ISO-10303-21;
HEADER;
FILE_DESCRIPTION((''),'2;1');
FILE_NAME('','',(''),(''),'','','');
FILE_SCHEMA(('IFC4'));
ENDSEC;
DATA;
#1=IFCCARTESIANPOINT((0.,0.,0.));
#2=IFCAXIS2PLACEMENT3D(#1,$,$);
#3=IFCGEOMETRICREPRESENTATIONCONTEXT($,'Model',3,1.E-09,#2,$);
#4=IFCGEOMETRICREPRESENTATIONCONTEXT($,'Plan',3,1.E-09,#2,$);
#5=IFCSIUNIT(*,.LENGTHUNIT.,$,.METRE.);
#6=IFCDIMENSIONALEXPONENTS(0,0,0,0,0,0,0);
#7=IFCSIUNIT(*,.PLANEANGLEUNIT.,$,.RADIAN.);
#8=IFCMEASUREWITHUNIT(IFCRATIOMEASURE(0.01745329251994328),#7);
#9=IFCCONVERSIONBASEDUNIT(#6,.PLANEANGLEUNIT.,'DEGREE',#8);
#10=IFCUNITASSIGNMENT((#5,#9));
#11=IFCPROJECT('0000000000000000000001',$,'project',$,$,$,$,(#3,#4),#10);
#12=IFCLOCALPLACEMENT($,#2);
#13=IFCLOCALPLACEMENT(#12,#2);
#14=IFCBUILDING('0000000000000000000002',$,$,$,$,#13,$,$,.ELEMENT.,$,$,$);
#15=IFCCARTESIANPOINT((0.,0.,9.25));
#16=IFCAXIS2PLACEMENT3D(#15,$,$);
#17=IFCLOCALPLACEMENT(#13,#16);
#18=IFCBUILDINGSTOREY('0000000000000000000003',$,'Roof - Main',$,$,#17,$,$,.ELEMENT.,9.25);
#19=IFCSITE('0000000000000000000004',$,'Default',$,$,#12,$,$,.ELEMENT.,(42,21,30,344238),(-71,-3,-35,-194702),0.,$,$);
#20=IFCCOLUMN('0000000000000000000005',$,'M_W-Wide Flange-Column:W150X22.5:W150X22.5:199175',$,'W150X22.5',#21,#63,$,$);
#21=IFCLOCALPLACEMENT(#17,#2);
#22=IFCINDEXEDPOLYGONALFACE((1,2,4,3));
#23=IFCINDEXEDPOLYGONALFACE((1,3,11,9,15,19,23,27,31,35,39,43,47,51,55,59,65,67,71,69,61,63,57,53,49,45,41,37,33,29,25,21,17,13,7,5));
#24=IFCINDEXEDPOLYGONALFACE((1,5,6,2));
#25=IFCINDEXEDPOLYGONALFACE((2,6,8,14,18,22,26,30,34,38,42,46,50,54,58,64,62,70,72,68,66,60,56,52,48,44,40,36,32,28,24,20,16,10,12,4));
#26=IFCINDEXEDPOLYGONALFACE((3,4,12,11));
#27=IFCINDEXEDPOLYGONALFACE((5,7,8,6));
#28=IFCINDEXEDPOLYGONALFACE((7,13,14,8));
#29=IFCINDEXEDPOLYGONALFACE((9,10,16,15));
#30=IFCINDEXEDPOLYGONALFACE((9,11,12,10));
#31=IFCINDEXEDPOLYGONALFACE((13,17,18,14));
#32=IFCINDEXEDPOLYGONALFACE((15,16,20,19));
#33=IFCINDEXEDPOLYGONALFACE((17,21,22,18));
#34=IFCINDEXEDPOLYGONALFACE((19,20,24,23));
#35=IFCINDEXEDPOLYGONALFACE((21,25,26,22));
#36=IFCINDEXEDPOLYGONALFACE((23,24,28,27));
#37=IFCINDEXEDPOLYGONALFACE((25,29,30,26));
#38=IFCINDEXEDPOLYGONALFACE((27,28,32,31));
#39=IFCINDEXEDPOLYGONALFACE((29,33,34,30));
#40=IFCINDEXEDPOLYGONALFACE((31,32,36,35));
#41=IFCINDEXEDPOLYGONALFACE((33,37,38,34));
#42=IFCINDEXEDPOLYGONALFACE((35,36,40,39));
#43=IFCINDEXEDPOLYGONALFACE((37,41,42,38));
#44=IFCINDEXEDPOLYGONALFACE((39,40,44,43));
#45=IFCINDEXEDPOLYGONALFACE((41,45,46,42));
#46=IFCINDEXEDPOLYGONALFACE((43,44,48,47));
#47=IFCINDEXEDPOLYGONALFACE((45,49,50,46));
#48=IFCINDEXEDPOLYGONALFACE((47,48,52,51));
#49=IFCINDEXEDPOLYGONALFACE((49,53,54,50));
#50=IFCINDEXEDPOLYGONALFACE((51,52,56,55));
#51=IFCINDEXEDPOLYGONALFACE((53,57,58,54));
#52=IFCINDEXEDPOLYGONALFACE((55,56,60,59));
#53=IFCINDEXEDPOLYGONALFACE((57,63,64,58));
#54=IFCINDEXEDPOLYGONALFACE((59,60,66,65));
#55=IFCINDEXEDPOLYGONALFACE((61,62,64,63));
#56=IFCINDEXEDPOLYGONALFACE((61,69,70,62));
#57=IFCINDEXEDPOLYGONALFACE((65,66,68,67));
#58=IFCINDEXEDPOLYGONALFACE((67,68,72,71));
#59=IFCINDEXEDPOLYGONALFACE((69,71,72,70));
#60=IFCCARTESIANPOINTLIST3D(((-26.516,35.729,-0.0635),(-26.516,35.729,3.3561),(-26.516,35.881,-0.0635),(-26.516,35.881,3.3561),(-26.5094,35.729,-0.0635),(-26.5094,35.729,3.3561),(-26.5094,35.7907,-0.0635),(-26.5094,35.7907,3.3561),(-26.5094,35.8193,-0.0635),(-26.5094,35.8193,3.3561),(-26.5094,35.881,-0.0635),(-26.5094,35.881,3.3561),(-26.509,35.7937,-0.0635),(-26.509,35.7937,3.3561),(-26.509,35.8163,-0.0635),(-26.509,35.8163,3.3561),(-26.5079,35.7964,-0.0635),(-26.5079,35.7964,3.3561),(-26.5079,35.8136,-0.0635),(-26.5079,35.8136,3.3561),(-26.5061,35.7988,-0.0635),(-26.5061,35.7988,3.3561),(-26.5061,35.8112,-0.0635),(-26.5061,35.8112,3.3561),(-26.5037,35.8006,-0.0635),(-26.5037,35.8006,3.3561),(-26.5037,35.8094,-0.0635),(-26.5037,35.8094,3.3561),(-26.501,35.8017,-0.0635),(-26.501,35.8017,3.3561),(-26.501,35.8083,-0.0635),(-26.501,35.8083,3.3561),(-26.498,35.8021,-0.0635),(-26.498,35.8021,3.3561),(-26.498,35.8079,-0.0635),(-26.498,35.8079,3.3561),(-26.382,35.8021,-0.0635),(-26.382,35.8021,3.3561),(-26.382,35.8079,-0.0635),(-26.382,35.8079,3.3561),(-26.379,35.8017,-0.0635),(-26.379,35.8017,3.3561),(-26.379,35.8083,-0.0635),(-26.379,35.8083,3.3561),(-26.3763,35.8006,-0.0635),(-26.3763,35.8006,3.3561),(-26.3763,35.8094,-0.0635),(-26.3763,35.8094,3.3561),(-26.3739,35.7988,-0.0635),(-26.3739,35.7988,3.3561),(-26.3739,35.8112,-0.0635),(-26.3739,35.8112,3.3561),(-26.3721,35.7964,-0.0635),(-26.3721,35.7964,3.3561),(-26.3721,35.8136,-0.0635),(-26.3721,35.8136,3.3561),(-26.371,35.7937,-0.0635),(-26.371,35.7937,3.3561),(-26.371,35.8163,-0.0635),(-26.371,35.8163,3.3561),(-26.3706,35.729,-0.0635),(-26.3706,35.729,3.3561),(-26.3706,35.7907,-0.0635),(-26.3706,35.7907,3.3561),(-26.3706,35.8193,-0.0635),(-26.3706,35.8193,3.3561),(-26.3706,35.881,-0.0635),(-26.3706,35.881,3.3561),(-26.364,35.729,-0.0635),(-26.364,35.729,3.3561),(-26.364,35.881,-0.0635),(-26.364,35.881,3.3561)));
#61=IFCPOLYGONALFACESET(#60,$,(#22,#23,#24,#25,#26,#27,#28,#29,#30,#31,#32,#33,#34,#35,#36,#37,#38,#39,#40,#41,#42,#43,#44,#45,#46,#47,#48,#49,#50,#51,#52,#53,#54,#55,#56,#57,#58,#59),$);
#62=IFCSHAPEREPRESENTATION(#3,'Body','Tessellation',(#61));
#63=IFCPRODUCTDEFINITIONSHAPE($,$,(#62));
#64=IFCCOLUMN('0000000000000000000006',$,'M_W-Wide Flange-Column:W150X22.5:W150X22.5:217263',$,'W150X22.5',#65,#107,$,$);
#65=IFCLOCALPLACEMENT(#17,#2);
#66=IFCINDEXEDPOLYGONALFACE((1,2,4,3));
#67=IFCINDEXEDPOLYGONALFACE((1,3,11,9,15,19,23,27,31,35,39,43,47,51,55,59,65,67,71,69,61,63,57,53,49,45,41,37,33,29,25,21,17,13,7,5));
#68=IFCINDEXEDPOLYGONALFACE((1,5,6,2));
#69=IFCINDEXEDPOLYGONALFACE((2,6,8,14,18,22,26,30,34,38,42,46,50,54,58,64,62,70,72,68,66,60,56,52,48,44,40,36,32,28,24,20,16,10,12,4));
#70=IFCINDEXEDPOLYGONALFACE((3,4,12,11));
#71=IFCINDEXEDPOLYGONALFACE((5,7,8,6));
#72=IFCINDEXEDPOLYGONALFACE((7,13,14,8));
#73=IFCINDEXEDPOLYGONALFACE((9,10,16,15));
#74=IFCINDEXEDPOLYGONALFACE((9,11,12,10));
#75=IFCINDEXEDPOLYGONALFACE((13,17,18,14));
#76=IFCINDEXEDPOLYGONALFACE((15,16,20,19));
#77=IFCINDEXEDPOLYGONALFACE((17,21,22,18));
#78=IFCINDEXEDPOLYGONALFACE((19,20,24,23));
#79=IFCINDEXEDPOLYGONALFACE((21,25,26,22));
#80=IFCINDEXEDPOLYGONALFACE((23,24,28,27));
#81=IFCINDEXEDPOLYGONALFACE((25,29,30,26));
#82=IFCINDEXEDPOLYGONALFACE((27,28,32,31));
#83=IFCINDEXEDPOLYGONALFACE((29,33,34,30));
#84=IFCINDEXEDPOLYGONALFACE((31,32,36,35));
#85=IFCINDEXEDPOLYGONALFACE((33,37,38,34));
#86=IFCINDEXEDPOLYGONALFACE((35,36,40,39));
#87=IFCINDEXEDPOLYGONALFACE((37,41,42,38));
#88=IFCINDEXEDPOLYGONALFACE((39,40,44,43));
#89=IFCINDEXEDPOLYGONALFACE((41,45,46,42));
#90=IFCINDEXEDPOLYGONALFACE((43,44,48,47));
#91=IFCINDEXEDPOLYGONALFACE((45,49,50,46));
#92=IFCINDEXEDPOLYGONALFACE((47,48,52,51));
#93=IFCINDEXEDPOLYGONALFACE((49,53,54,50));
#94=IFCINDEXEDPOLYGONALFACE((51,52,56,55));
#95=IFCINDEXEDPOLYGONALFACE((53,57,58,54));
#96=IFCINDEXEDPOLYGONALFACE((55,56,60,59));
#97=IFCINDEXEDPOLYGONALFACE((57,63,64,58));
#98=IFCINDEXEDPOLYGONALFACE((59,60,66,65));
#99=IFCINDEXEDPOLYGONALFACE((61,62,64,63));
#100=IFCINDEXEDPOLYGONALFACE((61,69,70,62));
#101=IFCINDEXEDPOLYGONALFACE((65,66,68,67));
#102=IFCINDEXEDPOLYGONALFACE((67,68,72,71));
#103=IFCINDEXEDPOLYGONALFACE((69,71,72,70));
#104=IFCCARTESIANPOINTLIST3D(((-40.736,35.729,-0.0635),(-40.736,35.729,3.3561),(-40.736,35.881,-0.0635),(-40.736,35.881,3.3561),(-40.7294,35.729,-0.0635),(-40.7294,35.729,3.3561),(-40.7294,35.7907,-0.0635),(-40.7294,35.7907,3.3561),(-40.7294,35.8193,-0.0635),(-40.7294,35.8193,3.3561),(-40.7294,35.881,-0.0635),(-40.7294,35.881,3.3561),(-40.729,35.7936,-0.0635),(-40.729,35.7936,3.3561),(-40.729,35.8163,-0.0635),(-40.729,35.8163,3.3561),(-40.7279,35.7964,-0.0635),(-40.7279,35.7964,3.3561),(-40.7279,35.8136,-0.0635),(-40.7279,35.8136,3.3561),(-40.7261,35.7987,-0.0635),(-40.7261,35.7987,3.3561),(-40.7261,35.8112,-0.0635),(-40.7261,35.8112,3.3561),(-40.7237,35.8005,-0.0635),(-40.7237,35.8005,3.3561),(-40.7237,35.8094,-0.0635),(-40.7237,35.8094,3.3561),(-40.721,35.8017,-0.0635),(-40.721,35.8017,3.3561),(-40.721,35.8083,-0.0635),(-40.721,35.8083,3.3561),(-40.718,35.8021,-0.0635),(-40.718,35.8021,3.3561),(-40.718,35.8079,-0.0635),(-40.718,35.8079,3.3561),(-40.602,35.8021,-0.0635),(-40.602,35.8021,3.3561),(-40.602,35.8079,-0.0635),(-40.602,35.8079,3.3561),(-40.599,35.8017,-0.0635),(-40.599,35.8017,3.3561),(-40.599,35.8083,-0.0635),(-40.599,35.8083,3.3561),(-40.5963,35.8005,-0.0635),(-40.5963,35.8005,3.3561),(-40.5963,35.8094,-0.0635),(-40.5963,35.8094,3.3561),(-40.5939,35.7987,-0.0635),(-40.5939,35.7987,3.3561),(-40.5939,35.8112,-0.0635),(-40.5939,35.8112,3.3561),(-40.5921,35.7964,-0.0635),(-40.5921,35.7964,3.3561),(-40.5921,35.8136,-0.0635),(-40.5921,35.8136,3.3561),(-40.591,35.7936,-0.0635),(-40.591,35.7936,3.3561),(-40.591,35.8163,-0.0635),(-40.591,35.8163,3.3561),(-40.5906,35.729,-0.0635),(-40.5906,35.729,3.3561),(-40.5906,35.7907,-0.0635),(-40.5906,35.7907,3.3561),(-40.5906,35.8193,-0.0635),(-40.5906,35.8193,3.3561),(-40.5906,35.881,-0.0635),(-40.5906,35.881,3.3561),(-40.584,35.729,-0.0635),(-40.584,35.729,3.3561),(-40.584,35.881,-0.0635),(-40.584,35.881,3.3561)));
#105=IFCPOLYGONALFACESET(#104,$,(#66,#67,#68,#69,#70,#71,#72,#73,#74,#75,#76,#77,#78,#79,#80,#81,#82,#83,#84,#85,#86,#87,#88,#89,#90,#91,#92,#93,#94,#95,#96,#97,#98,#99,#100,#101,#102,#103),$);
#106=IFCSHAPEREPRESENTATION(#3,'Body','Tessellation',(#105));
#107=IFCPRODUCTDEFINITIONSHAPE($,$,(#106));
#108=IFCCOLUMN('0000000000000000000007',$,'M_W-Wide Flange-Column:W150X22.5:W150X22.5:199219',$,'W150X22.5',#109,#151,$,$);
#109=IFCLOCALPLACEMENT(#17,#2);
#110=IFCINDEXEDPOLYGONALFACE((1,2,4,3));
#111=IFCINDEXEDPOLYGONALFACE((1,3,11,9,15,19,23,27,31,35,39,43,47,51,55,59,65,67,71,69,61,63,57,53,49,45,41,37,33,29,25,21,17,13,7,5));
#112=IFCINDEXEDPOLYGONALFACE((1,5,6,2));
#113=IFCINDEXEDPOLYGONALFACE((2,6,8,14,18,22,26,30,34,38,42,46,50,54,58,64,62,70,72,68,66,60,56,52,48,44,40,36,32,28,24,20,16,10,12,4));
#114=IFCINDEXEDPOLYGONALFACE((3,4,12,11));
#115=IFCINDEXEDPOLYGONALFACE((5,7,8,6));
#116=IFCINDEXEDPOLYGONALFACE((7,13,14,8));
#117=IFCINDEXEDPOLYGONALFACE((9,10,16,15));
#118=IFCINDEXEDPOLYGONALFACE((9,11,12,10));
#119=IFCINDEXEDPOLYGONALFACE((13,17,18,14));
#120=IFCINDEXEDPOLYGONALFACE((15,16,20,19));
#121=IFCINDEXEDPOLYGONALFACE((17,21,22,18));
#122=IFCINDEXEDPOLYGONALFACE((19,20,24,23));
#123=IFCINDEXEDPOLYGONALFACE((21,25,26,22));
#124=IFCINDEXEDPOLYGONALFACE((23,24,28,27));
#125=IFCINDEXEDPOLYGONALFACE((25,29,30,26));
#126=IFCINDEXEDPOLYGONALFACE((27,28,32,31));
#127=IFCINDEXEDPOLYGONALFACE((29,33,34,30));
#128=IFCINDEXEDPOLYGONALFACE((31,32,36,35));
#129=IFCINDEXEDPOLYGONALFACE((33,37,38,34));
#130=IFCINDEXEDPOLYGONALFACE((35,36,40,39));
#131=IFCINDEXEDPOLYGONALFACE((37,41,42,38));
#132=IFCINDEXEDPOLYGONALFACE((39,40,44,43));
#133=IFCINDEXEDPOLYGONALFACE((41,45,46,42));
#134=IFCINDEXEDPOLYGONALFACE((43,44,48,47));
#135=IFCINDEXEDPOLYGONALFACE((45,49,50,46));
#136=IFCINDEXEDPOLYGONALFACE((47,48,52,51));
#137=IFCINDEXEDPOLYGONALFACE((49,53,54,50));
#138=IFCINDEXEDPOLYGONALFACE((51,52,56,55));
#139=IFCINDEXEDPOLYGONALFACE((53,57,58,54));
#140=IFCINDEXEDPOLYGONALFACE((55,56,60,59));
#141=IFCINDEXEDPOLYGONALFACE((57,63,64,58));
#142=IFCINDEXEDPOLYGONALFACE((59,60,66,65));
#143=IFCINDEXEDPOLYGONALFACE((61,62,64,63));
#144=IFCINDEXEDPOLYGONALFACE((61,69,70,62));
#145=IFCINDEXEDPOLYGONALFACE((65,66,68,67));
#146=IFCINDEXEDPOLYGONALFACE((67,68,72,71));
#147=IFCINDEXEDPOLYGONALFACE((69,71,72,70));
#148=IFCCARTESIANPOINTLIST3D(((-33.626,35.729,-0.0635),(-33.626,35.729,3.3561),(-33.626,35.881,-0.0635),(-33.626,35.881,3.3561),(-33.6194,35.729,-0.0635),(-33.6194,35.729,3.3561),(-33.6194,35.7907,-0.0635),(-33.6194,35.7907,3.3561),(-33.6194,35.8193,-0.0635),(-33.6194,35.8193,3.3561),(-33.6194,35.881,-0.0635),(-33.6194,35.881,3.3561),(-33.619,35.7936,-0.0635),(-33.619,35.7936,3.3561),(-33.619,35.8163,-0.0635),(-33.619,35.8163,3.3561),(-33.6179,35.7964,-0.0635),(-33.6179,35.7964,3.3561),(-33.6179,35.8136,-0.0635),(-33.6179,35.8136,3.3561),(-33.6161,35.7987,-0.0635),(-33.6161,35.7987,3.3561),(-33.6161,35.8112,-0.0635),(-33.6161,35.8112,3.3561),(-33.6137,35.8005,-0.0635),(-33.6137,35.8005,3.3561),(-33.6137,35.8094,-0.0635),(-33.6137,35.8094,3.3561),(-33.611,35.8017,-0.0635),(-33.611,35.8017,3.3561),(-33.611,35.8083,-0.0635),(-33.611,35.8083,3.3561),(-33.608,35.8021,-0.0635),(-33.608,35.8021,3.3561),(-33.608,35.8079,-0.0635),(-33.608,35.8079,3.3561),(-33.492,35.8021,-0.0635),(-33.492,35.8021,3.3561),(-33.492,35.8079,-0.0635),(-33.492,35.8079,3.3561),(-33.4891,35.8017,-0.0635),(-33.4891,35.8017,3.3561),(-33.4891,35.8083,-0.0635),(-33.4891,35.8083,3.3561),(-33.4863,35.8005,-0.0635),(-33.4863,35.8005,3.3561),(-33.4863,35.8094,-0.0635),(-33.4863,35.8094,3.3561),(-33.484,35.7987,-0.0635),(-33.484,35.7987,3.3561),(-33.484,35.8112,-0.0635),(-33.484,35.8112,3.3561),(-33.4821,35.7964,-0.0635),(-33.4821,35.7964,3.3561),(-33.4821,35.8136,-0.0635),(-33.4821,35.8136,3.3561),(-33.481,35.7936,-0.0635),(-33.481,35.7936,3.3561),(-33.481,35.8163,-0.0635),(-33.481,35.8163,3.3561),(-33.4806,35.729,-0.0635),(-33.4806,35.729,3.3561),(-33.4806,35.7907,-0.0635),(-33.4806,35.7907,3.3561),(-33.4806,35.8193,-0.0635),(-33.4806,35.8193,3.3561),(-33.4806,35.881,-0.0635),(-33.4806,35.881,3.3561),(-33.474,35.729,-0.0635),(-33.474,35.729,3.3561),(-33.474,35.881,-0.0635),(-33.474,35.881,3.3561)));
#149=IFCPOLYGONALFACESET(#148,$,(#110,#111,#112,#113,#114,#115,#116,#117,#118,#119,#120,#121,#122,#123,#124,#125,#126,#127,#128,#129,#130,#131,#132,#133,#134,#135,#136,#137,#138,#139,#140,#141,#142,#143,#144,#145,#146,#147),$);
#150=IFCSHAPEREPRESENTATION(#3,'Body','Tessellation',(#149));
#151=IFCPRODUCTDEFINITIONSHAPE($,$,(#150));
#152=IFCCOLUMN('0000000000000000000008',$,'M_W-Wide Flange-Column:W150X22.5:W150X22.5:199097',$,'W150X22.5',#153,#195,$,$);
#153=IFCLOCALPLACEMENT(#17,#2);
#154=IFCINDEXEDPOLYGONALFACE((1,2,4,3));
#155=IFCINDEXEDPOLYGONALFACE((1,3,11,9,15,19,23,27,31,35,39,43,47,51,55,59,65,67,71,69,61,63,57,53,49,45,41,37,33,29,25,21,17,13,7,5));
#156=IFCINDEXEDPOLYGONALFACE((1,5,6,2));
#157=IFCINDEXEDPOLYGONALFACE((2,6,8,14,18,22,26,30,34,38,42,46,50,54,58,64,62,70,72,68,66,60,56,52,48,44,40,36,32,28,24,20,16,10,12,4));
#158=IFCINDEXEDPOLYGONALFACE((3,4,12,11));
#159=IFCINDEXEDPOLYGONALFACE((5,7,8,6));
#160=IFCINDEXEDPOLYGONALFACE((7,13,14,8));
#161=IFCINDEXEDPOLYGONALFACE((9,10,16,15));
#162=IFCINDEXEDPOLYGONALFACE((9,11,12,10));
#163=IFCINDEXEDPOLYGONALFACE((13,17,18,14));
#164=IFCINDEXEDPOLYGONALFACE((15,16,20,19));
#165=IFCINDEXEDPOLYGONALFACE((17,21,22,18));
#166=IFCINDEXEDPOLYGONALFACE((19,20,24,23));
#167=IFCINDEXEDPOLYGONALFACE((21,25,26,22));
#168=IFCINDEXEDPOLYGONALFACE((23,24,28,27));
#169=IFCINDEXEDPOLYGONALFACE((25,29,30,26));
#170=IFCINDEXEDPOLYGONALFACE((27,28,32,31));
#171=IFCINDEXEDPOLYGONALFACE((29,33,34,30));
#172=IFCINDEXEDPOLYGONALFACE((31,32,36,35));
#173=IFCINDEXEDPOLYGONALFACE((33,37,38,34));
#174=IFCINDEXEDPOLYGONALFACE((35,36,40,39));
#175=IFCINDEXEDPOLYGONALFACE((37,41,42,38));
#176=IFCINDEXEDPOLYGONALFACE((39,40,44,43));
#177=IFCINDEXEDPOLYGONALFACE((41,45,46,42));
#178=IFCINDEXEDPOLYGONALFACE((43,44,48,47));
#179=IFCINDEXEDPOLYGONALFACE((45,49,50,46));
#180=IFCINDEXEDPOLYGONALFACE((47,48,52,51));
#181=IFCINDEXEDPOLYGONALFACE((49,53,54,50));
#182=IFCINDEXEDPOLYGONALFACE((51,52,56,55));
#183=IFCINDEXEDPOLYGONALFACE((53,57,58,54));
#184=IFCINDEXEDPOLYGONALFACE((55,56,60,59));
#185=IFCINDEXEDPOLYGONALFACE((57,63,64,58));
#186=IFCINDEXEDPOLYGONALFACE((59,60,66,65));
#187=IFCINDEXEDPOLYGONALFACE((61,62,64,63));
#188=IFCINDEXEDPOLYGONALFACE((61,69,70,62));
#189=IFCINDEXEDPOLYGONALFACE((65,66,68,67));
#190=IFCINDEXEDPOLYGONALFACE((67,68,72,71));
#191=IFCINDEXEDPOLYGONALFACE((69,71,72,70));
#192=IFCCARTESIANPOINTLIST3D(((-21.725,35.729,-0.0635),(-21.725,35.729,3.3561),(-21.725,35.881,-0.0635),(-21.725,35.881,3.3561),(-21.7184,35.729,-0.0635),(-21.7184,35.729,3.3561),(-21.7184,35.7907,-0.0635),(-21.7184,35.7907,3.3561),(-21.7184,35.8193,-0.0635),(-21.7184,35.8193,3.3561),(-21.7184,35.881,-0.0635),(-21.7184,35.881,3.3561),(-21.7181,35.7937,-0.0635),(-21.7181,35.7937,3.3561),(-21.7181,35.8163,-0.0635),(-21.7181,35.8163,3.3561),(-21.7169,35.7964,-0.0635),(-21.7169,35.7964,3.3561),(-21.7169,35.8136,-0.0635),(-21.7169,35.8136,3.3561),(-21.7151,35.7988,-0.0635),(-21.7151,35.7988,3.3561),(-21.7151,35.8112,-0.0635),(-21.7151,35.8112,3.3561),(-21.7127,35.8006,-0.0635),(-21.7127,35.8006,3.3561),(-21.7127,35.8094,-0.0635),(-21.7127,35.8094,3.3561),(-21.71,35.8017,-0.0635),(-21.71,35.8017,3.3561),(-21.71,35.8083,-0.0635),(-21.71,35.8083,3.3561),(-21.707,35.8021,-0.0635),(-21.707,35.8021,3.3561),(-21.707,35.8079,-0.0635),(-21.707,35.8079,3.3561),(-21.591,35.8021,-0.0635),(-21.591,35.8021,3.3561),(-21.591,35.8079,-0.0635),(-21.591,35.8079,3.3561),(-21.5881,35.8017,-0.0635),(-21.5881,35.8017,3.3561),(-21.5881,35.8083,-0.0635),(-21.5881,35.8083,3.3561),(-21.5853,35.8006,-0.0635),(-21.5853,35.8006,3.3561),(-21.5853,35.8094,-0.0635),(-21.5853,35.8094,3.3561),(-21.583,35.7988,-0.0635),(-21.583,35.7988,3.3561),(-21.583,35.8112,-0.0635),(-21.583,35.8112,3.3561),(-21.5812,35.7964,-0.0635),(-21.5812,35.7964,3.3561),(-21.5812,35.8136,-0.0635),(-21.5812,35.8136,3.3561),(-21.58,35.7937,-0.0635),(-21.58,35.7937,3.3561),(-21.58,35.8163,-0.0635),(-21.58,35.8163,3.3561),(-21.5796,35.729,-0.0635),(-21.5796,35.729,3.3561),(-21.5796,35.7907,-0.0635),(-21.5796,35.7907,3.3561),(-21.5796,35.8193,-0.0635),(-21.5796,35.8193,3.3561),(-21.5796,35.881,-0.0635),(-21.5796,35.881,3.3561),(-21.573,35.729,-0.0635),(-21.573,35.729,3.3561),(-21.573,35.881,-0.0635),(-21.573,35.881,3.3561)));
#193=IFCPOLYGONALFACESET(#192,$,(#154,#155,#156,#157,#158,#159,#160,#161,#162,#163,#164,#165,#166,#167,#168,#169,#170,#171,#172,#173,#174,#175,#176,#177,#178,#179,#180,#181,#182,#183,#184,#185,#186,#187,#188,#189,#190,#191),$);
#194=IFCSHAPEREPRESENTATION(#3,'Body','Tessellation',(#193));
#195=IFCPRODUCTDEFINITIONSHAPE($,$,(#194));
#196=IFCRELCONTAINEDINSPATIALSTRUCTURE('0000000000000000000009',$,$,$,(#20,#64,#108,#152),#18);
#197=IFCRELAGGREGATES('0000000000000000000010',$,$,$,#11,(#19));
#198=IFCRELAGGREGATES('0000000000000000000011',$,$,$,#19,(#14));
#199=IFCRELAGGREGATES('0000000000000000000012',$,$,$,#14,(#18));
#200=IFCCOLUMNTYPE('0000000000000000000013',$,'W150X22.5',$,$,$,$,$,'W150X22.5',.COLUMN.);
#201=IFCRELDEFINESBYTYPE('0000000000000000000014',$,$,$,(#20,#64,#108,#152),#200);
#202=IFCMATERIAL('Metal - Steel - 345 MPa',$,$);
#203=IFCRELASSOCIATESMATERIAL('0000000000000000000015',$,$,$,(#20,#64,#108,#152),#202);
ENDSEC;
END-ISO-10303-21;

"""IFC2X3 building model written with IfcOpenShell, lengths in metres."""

from ifc_helpers import new_model, entity, si_unit, converted_unit, frame, frame_2d, origin, place, context, project, spatial, polyline, circle_curve, parameter, trimmed, segment, composite_curve, outline, extrude, source, transform, mapped, material, type_object, type_shapes, element, save


model = new_model("IFC2X3")

# Units and contexts
model_context = context("Model", 3, precision=1e-09, world=origin())
plan_context = context("Plan", 3, precision=1e-09, world=origin())
ifc_project = project(units=[si_unit("LENGTHUNIT", "METRE"), converted_unit("PLANEANGLEUNIT", "DEGREE", entity("IfcRatioMeasure", 0.01745329251994328), si_unit("PLANEANGLEUNIT", "RADIAN"), dimensions=[0, 0, 0, 0, 0, 0, 0])], contexts=[model_context, plan_context])

# Site, building, storey
site_placement = place(None, origin())
site = spatial("IfcSite", under=ifc_project, at=site_placement, Name="Default", CompositionType="ELEMENT", RefLatitude=(42, 21, 30, 344238), RefLongitude=(-71, -3, -35, -194702), RefElevation=0.0)
building_placement = place(site_placement, origin())
building = spatial("IfcBuilding", under=site, at=building_placement, CompositionType="ELEMENT")
storey_placement = place(building_placement, frame((0.0, 0.0, 9.25)))
storey = spatial("IfcBuildingStorey", under=building, at=storey_placement, Name="Roof - Main", CompositionType="ELEMENT", Elevation=9.25)

# Columns
ifc_material_1 = material(Name="Metal - Steel - 345 MPa")
column_type_1 = type_object("IfcColumnType", Name="W150X22.5", ElementType="W150X22.5", PredefinedType="COLUMN")
shared_shape_1 = source(origin(), model_context, "Body", "SweptSolid", [
    extrude(outline(composite_curve([segment(polyline([(-0.076, -0.076), (0.076, -0.076)]), True, "CONTINUOUS"), segment(polyline([(0.076, -0.076), (0.076, -0.0694)]), True, "CONTINUOUS"), segment(polyline([(0.076, -0.0694), (0.0143, -0.0694)]), True, "CONTINUOUS"), segment(trimmed(circle_curve(frame_2d((0.0143, -0.058), x_axis=(-1.0, 0.0)), 0.0114), [parameter(0.0)], [parameter(90.0)], True, "PARAMETER"), False, "CONTINUOUS"), segment(polyline([(0.0029, -0.058), (0.0029, 0.058)]), True, "CONTINUOUS"), segment(trimmed(circle_curve(frame_2d((0.0143, 0.058), x_axis=(-1.0, 0.0)), 0.0114), [parameter(270.0)], [parameter(0.0)], True, "PARAMETER"), False, "CONTINUOUS"), segment(polyline([(0.0143, 0.0694), (0.076, 0.0694)]), True, "CONTINUOUS"), segment(polyline([(0.076, 0.0694), (0.076, 0.076)]), True, "CONTINUOUS"), segment(polyline([(0.076, 0.076), (-0.076, 0.076)]), True, "CONTINUOUS"), segment(polyline([(-0.076, 0.076), (-0.076, 0.0694)]), True, "CONTINUOUS"), segment(polyline([(-0.076, 0.0694), (-0.0143, 0.0694)]), True, "CONTINUOUS"), segment(trimmed(circle_curve(frame_2d((-0.0143, 0.058), x_axis=(-1.0, 0.0)), 0.0114), [parameter(180.0)], [parameter(270.0)], True, "PARAMETER"), False, "CONTINUOUS"), segment(polyline([(-0.0029, 0.058), (-0.0029, -0.058)]), True, "CONTINUOUS"), segment(trimmed(circle_curve(frame_2d((-0.0143, -0.058), x_axis=(-1.0, 0.0)), 0.0114), [parameter(90.0)], [parameter(180.0)], True, "PARAMETER"), False, "CONTINUOUS"), segment(polyline([(-0.0143, -0.0694), (-0.076, -0.0694)]), True, "CONTINUOUS"), segment(polyline([(-0.076, -0.0694), (-0.076, -0.076)]), True, "CONTINUOUS")], self_intersect=False)), frame((0.0, 0.0, 9.1865), z_axis=(0.0, 0.0, 1.0), x_axis=(-1.0, 0.0, 0.0)), (0.0, 0.0, 1.0), 3.4196),
])
type_shapes(column_type_1, [shared_shape_1])
for number, where, z_axis, x_axis, name in (
    (1, (-26.44, 35.805, -9.25), (0.0, 0.0, 1.0), (0.0, 1.0, 0.0), "M_W-Wide Flange-Column:W150X22.5:W150X22.5:199175"),
    (2, (-40.66, 35.805, -9.25), (0.0, 0.0, 1.0), (0.0, 1.0, 0.0), "M_W-Wide Flange-Column:W150X22.5:W150X22.5:217263"),
    (3, (-33.55, 35.805, -9.25), (0.0, 0.0, 1.0), (0.0, 1.0, 0.0), "M_W-Wide Flange-Column:W150X22.5:W150X22.5:199219"),
    (4, (-21.649, 35.805, -9.25), (0.0, 0.0, 1.0), (0.0, 1.0, 0.0), "M_W-Wide Flange-Column:W150X22.5:W150X22.5:199097"),
):
    element("IfcColumn", number, at=place(storey_placement, frame(where, z_axis=z_axis, x_axis=x_axis)), inside=storey, type_object=column_type_1, material=ifc_material_1, Name=name, ObjectType="W150X22.5", context=model_context, shape_type="MappedRepresentation", body=[
        mapped(shared_shape_1, transform((0.0, 0.0, 0.0), scale=1.0)),
    ])

save(model, "model.ifc")
